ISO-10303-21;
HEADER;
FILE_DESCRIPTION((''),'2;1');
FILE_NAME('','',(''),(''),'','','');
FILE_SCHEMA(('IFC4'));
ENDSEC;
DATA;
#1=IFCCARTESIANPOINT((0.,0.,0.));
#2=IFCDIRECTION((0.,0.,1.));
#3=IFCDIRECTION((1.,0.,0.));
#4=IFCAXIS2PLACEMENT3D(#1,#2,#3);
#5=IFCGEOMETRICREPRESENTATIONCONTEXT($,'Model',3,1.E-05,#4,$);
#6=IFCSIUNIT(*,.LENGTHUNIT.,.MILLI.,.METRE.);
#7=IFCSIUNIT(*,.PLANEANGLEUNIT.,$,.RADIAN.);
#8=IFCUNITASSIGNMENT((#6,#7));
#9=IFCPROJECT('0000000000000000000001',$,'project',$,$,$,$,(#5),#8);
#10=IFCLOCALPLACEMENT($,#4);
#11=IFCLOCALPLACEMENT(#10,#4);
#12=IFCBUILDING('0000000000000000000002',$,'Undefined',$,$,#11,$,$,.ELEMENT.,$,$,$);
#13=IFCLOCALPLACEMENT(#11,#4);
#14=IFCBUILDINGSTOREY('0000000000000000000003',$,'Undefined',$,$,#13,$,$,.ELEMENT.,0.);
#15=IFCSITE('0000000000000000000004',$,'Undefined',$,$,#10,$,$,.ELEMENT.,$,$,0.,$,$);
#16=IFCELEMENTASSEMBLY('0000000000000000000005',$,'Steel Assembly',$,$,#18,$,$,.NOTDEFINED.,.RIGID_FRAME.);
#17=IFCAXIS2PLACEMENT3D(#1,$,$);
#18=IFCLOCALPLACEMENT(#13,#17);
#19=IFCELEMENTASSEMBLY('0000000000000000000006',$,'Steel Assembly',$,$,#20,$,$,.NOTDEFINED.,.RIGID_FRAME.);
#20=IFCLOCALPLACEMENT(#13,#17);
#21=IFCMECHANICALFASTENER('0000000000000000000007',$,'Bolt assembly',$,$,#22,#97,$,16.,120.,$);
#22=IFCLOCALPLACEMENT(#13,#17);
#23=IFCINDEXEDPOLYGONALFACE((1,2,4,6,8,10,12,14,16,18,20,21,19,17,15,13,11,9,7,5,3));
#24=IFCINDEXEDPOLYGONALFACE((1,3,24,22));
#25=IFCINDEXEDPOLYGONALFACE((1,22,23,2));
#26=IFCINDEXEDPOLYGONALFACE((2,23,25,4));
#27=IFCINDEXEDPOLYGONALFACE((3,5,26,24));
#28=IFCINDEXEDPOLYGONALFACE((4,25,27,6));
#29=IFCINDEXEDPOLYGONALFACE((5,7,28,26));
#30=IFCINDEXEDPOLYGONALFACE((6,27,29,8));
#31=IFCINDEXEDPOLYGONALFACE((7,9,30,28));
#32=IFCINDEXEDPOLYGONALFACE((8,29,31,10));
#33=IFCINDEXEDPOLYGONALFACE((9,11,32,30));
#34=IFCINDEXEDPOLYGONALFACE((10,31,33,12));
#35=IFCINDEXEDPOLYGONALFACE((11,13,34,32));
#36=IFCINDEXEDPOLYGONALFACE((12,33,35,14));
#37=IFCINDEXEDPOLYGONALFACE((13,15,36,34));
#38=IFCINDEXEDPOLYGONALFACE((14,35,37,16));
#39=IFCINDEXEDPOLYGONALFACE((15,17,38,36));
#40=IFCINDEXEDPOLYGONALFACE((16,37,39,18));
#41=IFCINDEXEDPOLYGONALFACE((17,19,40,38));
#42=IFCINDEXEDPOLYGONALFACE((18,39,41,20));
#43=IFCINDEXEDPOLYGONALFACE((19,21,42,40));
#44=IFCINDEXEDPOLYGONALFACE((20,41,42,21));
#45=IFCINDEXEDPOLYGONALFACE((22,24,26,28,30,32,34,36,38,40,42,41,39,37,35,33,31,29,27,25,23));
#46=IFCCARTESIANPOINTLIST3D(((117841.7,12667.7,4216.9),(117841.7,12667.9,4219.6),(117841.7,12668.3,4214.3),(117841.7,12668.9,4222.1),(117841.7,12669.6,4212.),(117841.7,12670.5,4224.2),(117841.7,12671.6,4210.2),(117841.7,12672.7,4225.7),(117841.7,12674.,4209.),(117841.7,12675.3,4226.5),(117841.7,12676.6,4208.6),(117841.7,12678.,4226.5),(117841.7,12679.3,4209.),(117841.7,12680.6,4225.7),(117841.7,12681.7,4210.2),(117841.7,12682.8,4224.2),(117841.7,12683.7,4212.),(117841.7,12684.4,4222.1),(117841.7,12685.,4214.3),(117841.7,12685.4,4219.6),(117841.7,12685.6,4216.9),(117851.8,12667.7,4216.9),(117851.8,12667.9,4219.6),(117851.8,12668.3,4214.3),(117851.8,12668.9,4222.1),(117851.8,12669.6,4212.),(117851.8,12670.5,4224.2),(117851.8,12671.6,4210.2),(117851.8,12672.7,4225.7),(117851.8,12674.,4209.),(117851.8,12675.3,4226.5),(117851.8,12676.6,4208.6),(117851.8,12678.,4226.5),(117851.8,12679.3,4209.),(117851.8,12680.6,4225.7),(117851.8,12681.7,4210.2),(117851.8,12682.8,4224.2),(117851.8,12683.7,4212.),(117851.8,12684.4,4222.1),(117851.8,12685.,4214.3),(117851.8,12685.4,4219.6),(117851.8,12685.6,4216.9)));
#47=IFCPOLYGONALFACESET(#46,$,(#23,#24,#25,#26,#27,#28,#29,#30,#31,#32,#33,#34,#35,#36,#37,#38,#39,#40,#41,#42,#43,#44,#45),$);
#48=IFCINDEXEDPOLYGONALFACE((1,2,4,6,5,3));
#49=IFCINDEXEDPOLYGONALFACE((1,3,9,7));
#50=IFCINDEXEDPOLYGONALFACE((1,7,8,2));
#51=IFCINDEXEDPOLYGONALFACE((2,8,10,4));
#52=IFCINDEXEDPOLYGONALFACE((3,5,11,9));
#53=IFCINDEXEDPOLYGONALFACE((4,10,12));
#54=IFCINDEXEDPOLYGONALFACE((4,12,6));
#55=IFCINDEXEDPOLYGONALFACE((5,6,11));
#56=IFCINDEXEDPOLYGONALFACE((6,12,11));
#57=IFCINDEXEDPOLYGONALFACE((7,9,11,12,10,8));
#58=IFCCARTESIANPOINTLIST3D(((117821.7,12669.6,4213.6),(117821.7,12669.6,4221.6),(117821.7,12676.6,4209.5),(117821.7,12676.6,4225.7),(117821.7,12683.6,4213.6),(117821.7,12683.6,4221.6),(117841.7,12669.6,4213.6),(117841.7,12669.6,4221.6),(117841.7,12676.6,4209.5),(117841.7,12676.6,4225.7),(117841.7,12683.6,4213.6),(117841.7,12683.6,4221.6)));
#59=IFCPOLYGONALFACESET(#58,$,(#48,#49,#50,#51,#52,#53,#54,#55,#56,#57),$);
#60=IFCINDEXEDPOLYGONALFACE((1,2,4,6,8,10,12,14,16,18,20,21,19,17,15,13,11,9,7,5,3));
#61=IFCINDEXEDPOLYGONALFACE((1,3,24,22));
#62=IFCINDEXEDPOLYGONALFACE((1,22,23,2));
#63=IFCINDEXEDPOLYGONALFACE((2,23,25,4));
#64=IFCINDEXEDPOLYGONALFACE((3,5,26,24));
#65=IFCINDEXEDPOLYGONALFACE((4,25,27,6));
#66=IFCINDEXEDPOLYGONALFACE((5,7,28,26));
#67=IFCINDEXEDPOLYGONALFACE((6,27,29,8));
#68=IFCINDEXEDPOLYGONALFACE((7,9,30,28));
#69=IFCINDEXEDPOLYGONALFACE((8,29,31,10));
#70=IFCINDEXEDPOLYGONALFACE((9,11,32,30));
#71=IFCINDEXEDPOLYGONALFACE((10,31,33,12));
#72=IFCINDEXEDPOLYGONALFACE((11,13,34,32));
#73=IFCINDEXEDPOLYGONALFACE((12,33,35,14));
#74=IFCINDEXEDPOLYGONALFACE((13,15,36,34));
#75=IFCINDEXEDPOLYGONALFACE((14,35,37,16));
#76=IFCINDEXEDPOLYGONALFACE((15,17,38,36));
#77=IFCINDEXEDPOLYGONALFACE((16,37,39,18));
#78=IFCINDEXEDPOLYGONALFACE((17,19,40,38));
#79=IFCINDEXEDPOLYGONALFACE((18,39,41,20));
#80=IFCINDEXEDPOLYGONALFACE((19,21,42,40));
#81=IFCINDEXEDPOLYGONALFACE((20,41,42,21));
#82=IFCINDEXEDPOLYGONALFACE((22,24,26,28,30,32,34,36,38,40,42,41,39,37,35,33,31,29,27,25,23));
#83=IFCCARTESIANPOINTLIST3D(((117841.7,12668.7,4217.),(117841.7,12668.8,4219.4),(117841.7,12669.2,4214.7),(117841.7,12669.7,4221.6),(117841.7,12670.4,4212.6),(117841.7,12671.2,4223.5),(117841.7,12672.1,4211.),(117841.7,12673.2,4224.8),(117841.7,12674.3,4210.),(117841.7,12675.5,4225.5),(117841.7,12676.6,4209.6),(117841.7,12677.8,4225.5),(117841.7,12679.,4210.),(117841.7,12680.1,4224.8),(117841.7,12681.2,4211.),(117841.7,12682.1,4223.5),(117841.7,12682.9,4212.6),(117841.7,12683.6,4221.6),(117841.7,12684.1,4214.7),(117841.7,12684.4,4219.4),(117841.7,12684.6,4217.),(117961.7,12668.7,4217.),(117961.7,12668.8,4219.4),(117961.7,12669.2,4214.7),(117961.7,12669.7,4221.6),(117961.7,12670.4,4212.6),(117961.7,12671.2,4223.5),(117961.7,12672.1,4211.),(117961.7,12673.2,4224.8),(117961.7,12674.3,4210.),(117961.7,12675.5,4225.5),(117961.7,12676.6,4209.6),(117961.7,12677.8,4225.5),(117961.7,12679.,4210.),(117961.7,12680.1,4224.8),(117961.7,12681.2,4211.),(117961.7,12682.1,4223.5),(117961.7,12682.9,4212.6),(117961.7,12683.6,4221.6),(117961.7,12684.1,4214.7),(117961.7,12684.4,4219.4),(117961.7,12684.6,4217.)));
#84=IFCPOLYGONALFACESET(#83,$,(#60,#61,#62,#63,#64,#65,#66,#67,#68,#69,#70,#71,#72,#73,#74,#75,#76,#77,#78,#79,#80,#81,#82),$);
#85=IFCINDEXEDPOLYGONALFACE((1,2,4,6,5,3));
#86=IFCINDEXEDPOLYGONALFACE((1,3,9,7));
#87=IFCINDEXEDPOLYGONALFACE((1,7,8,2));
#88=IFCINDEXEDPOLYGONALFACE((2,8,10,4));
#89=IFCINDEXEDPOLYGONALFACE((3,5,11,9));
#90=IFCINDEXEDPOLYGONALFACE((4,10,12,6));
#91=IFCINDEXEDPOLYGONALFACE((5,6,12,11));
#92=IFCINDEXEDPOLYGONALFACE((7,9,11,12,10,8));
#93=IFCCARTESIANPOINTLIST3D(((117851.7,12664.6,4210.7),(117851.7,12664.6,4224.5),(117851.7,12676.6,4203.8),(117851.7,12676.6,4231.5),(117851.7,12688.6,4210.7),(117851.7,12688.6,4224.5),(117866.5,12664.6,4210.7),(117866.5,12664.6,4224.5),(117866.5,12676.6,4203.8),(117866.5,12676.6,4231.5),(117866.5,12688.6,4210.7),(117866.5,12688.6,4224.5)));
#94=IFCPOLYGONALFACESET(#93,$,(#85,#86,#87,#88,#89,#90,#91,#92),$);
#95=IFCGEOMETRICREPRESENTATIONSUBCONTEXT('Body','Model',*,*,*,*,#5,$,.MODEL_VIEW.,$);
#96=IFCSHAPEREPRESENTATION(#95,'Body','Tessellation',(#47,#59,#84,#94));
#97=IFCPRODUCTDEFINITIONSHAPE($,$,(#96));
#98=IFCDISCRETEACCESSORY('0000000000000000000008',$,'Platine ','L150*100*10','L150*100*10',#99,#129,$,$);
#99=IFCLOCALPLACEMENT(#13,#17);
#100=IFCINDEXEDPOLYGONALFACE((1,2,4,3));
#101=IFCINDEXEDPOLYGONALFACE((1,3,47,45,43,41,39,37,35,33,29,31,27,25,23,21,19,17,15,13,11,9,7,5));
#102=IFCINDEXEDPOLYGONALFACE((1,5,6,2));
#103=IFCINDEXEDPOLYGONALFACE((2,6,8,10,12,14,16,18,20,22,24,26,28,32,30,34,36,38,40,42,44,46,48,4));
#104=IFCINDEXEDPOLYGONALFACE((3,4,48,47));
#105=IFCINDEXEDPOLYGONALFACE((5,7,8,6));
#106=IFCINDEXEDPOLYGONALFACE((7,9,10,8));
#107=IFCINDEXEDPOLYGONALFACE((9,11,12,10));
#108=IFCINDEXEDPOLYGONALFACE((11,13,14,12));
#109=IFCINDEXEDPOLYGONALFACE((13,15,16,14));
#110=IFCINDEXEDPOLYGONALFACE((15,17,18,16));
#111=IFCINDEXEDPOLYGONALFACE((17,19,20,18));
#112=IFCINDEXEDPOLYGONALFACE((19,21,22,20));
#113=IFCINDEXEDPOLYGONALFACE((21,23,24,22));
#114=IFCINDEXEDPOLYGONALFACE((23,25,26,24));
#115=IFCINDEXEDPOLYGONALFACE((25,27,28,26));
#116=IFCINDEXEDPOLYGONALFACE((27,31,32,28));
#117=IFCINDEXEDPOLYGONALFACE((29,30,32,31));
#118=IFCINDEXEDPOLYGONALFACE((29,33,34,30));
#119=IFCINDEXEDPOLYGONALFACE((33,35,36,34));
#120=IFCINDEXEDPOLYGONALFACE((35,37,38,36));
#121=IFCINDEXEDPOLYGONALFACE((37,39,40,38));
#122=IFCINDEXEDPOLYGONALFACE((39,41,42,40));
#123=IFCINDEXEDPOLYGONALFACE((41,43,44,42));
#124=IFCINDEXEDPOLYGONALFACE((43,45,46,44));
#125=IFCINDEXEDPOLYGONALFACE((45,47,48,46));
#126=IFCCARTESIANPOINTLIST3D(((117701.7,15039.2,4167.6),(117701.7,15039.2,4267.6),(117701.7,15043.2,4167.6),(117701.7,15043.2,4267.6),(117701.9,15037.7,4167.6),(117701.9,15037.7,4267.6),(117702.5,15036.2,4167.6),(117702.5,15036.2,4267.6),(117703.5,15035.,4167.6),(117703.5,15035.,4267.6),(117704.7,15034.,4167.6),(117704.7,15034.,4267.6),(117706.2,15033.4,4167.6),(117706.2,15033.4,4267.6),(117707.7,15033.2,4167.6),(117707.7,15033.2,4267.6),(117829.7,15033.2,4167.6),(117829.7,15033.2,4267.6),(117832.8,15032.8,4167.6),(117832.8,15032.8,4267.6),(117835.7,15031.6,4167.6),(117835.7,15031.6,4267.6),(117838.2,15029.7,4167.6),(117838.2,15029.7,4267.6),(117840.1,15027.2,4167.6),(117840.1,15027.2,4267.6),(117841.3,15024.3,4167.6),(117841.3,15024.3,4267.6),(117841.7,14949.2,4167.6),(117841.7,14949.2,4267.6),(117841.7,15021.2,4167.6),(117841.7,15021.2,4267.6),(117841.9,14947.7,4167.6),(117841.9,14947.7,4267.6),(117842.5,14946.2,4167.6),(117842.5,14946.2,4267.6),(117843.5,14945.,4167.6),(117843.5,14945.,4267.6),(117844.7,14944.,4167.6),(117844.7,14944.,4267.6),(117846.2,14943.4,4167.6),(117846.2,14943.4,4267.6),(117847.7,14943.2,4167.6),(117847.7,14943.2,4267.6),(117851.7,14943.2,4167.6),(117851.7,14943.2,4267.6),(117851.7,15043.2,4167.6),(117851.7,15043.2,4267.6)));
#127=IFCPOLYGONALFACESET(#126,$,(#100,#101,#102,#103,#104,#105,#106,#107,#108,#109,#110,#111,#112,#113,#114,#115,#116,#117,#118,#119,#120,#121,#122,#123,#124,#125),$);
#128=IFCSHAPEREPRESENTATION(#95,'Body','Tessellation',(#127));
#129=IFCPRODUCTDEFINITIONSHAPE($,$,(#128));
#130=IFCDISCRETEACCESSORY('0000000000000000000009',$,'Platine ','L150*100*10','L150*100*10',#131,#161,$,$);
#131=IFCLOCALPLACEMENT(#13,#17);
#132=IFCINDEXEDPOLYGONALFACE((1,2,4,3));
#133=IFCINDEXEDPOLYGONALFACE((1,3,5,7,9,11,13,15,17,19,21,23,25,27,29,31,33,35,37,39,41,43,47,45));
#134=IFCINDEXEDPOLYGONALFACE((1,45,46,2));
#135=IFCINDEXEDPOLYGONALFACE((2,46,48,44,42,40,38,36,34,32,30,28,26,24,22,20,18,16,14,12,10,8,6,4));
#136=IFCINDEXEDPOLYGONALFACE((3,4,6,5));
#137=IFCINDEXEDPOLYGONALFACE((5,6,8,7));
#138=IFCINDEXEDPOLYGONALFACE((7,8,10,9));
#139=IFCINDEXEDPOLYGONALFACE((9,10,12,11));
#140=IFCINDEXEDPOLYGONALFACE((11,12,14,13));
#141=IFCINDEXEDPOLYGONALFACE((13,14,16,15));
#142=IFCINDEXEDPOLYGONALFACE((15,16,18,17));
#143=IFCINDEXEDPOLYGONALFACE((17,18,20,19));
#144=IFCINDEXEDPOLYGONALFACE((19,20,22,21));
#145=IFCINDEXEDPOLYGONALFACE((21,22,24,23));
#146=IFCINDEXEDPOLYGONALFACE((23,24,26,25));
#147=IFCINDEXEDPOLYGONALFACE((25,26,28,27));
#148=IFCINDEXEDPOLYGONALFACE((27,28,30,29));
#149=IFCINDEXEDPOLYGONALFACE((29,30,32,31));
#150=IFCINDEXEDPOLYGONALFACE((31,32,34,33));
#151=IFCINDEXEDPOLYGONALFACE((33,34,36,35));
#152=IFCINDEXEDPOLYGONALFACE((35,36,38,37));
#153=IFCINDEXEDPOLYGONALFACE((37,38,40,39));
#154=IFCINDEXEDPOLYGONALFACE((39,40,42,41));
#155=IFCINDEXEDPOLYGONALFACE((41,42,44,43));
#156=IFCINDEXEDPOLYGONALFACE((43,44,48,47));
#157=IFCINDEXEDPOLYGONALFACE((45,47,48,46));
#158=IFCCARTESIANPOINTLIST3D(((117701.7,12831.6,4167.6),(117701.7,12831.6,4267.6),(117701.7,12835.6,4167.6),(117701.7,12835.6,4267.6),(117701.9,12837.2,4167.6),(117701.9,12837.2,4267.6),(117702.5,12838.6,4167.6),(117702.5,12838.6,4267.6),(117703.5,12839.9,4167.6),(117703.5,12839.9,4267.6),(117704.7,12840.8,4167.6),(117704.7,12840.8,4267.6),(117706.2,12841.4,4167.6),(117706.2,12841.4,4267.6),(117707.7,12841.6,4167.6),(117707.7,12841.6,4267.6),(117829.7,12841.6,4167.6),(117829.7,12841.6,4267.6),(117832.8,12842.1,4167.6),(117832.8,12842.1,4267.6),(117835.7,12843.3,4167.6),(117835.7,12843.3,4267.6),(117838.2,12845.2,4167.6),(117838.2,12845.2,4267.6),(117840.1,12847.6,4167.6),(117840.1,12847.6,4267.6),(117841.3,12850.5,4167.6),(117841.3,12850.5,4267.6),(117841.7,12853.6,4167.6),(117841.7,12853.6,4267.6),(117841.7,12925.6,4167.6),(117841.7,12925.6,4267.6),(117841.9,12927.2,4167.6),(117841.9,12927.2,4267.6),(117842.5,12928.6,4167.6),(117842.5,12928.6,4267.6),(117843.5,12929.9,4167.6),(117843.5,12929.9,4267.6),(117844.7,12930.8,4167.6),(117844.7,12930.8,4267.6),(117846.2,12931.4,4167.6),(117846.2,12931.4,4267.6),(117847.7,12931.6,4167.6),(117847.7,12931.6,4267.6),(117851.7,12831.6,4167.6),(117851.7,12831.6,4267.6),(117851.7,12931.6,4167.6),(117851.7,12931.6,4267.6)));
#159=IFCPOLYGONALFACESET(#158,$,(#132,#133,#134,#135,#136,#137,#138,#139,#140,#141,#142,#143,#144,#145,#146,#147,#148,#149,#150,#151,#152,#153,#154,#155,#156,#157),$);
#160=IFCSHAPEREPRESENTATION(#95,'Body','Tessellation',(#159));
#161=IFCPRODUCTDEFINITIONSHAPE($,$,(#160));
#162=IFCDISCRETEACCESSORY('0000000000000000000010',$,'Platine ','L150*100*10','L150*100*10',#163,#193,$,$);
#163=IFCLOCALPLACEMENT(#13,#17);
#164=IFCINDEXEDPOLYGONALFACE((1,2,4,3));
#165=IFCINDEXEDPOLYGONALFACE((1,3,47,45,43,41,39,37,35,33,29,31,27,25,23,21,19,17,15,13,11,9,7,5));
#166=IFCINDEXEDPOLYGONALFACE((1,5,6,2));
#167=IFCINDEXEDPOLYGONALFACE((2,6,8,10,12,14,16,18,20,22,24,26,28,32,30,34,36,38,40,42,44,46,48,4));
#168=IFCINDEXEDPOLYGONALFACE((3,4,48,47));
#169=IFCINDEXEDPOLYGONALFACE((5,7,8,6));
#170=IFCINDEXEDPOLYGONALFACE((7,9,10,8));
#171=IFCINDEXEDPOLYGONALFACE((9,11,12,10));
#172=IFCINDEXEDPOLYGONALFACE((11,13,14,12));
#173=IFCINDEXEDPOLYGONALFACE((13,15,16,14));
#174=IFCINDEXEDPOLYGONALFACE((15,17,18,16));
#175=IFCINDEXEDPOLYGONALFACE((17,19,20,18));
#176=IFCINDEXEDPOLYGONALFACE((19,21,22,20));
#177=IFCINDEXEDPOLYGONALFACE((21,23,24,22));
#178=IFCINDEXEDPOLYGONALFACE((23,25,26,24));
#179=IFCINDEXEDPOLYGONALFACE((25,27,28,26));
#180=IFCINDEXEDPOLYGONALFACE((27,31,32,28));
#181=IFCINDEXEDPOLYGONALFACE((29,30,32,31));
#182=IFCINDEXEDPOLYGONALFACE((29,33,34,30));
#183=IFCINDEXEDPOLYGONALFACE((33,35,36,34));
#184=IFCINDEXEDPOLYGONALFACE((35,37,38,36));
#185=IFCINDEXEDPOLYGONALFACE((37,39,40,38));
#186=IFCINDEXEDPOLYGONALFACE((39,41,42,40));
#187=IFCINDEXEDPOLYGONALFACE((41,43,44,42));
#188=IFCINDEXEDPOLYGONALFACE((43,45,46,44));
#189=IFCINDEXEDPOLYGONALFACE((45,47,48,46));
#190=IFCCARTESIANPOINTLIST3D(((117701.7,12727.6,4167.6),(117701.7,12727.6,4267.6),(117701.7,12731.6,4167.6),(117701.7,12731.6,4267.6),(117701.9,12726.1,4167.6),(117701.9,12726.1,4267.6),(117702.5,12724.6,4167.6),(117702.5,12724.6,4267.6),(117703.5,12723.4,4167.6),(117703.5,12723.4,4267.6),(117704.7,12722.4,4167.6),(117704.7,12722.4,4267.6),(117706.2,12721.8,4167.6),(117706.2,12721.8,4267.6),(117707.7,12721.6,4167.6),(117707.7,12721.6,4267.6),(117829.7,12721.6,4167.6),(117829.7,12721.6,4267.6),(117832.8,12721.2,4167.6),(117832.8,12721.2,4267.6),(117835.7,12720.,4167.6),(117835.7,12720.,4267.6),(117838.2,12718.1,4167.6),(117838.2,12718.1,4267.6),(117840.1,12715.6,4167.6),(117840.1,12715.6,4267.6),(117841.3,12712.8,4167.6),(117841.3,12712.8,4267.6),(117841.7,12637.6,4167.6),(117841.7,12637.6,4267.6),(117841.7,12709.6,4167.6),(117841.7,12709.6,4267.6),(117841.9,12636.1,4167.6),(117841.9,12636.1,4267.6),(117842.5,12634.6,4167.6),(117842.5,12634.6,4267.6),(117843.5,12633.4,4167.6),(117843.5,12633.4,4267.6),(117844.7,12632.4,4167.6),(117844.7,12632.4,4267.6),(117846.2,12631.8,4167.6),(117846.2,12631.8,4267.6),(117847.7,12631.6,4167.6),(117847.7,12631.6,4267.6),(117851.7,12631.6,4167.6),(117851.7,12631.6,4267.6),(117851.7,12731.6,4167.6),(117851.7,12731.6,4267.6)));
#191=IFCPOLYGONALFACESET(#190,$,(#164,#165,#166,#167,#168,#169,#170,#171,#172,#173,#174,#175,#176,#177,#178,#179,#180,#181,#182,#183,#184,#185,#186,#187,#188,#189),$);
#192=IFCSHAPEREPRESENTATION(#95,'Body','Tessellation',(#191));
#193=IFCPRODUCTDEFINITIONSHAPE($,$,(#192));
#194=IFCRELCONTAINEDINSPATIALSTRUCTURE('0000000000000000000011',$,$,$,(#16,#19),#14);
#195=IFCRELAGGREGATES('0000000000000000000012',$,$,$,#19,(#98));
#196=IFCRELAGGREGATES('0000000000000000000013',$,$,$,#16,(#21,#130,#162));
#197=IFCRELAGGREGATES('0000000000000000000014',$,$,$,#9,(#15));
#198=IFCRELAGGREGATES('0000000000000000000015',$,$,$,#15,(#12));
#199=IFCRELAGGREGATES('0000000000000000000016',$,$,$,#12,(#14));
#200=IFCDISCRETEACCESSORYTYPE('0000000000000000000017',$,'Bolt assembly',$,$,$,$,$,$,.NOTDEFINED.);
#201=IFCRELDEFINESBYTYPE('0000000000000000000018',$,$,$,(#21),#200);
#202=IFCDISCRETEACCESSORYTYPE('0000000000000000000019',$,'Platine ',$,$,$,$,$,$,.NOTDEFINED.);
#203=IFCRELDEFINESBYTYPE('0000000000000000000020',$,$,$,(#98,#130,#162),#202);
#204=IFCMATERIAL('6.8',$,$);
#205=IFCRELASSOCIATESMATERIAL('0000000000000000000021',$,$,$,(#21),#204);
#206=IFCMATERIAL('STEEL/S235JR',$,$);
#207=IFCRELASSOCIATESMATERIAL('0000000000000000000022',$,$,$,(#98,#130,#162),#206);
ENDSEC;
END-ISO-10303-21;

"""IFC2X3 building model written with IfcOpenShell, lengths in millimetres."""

from ifc_helpers import new_model, si_unit, frame, origin_with_axes, origin_2d_with_axis, place, context, subcontext, project, spatial, polyline, circle, l_section, outline, extrude, source, transform, mapped, material, type_object, element, aggregate, save


model = new_model("IFC2X3")

# Units and contexts
model_context = context("Model", 3, precision=1e-05, world=origin_with_axes())
body_context = subcontext(model_context, "Body", "Model", "MODEL_VIEW")
ifc_project = project(units=[si_unit("LENGTHUNIT", "METRE", prefix="MILLI"), si_unit("PLANEANGLEUNIT", "RADIAN")], contexts=[model_context])

# Site, building, storey
site_placement = place(None, origin_with_axes())
site = spatial("IfcSite", under=ifc_project, at=site_placement, Name="Undefined", CompositionType="ELEMENT", RefElevation=0.0)
building_placement = place(site_placement, origin_with_axes())
building = spatial("IfcBuilding", under=site, at=building_placement, Name="Undefined", CompositionType="ELEMENT")
storey_placement = place(building_placement, origin_with_axes())
storey = spatial("IfcBuildingStorey", under=building, at=storey_placement, Name="Undefined", CompositionType="ELEMENT", Elevation=0.0)

# Shared definitions
ifc_material_1 = material(Name="STEEL/S235JR")

# Element assembly
assembly_1_placement = place(storey_placement, origin_with_axes())
assembly_1 = element("IfcElementAssembly", 1, at=assembly_1_placement, inside=storey, Name="Steel Assembly", AssemblyPlace="NOTDEFINED", PredefinedType="RIGID_FRAME")

# Shared definitions
discrete_accessory_type_1 = type_object("IfcDiscreteAccessoryType", Name="Bolt assembly")

# Element assembly
assembly_2_placement = place(storey_placement, origin_with_axes())
assembly_2 = element("IfcElementAssembly", 2, at=assembly_2_placement, inside=storey, Name="Steel Assembly", AssemblyPlace="NOTDEFINED", PredefinedType="RIGID_FRAME")
ifc_material_2 = material(Name="6.8")
shared_shape_1 = source(origin_with_axes(), body_context, "Body", "SweptSolid", [
    extrude(circle(Radius=9.0, at=origin_2d_with_axis()), frame((0.0, 0.0, 0.0), z_axis=(0.0, 1.0, 0.0), x_axis=(1.0, 0.0, 0.0)), (0.0, 0.0, 1.0), 10.1),
    extrude(outline(polyline([(8.1, 0.0), (4.0, 7.0), (-4.0, 7.0), (-8.1, 0.0), (-4.0, -7.0), (4.0, -7.0), (8.1, 0.0)])), frame((0.0, -20.0, 0.0), z_axis=(0.0, 1.0, 0.0), x_axis=(1.0, 0.0, 0.0)), (0.0, 0.0, 1.0), 20.0),
    extrude(circle(Radius=8.0, at=origin_2d_with_axis()), frame((0.0, 0.0, 0.0), z_axis=(0.0, 1.0, 0.0), x_axis=(1.0, 0.0, 0.0)), (0.0, 0.0, 1.0), 120.0),
    extrude(outline(polyline([(13.9, 0.0), (6.9, 12.0), (-6.9, 12.0), (-13.9, 0.0), (-6.9, -12.0), (6.9, -12.0), (13.9, 0.0)])), frame((0.0, 10.0, 0.0), z_axis=(0.0, 1.0, 0.0), x_axis=(1.0, 0.0, 0.0)), (0.0, 0.0, 1.0), 14.8),
])

# Mechanical fastener
mechanical_fastener_1_placement = place(assembly_1_placement, frame((117841.7, 12676.6, 4217.6), z_axis=(0.0, -1.0, -0.000006), x_axis=(0.0, 0.000006, -1.0)))
mechanical_fastener_1 = element("IfcMechanicalFastener", 3, at=mechanical_fastener_1_placement, type_object=discrete_accessory_type_1, material=ifc_material_2, Name="Bolt assembly", NominalDiameter=16.0, NominalLength=120.0, context=body_context, shape_type="MappedRepresentation", body=[
    mapped(shared_shape_1, transform((0.0, 0.0, 0.0))),
])

# Discrete accessories
discrete_accessory_type_2 = type_object("IfcDiscreteAccessoryType", Name="Platine ")
discrete_accessory_1_placement = place(assembly_2_placement, frame((117776.7, 14993.2, 4167.6), z_axis=(0.0, 0.0, 1.0), x_axis=(1.0, 0.0, 0.0)))
discrete_accessory_1 = element("IfcDiscreteAccessory", 4, at=discrete_accessory_1_placement, type_object=discrete_accessory_type_2, material=ifc_material_1, Name="Platine ", Description="L150*100*10", ObjectType="L150*100*10", context=body_context, shape_type="SweptSolid", body=[
    extrude(l_section(Depth=150.0, Width=100.0, Thickness=10.0, FilletRadius=12.0, EdgeRadius=6.0, at=origin_2d_with_axis()), frame((0.0, 0.0, 100.0), z_axis=(0.0, 0.0, -1.0), x_axis=(0.0, -1.0, 0.0)), (0.0, 0.0, 1.0), 100.0),
])
aggregate(assembly_2, [discrete_accessory_1])
discrete_accessory_2_placement = place(assembly_1_placement, frame((117776.7, 12881.6, 4267.6), z_axis=(-1.0, 0.0, 0.0), x_axis=(0.0, 0.000006, -1.0)))
discrete_accessory_2 = element("IfcDiscreteAccessory", 5, at=discrete_accessory_2_placement, type_object=discrete_accessory_type_2, material=ifc_material_1, Name="Platine ", Description="L150*100*10", ObjectType="L150*100*10", context=body_context, shape_type="SweptSolid", body=[
    extrude(l_section(Depth=150.0, Width=100.0, Thickness=10.0, FilletRadius=12.0, EdgeRadius=6.0, at=origin_2d_with_axis()), frame((100.0, 0.0, 0.0), z_axis=(-1.0, 0.0, 0.0), x_axis=(0.0, -1.0, 0.0)), (0.0, 0.0, 1.0), 100.0),
])
discrete_accessory_3_placement = place(assembly_1_placement, frame((117776.7, 12681.6, 4167.6), z_axis=(0.0, 0.0, 1.0), x_axis=(1.0, 0.0, 0.0)))
discrete_accessory_3 = element("IfcDiscreteAccessory", 6, at=discrete_accessory_3_placement, type_object=discrete_accessory_type_2, material=ifc_material_1, Name="Platine ", Description="L150*100*10", ObjectType="L150*100*10", context=body_context, shape_type="SweptSolid", body=[
    extrude(l_section(Depth=150.0, Width=100.0, Thickness=10.0, FilletRadius=12.0, EdgeRadius=6.0, at=origin_2d_with_axis()), frame((0.0, 0.0, 100.0), z_axis=(0.0, 0.0, -1.0), x_axis=(0.0, -1.0, 0.0)), (0.0, 0.0, 1.0), 100.0),
])

aggregate(assembly_1, [mechanical_fastener_1, discrete_accessory_2, discrete_accessory_3])

save(model, "model.ifc")
